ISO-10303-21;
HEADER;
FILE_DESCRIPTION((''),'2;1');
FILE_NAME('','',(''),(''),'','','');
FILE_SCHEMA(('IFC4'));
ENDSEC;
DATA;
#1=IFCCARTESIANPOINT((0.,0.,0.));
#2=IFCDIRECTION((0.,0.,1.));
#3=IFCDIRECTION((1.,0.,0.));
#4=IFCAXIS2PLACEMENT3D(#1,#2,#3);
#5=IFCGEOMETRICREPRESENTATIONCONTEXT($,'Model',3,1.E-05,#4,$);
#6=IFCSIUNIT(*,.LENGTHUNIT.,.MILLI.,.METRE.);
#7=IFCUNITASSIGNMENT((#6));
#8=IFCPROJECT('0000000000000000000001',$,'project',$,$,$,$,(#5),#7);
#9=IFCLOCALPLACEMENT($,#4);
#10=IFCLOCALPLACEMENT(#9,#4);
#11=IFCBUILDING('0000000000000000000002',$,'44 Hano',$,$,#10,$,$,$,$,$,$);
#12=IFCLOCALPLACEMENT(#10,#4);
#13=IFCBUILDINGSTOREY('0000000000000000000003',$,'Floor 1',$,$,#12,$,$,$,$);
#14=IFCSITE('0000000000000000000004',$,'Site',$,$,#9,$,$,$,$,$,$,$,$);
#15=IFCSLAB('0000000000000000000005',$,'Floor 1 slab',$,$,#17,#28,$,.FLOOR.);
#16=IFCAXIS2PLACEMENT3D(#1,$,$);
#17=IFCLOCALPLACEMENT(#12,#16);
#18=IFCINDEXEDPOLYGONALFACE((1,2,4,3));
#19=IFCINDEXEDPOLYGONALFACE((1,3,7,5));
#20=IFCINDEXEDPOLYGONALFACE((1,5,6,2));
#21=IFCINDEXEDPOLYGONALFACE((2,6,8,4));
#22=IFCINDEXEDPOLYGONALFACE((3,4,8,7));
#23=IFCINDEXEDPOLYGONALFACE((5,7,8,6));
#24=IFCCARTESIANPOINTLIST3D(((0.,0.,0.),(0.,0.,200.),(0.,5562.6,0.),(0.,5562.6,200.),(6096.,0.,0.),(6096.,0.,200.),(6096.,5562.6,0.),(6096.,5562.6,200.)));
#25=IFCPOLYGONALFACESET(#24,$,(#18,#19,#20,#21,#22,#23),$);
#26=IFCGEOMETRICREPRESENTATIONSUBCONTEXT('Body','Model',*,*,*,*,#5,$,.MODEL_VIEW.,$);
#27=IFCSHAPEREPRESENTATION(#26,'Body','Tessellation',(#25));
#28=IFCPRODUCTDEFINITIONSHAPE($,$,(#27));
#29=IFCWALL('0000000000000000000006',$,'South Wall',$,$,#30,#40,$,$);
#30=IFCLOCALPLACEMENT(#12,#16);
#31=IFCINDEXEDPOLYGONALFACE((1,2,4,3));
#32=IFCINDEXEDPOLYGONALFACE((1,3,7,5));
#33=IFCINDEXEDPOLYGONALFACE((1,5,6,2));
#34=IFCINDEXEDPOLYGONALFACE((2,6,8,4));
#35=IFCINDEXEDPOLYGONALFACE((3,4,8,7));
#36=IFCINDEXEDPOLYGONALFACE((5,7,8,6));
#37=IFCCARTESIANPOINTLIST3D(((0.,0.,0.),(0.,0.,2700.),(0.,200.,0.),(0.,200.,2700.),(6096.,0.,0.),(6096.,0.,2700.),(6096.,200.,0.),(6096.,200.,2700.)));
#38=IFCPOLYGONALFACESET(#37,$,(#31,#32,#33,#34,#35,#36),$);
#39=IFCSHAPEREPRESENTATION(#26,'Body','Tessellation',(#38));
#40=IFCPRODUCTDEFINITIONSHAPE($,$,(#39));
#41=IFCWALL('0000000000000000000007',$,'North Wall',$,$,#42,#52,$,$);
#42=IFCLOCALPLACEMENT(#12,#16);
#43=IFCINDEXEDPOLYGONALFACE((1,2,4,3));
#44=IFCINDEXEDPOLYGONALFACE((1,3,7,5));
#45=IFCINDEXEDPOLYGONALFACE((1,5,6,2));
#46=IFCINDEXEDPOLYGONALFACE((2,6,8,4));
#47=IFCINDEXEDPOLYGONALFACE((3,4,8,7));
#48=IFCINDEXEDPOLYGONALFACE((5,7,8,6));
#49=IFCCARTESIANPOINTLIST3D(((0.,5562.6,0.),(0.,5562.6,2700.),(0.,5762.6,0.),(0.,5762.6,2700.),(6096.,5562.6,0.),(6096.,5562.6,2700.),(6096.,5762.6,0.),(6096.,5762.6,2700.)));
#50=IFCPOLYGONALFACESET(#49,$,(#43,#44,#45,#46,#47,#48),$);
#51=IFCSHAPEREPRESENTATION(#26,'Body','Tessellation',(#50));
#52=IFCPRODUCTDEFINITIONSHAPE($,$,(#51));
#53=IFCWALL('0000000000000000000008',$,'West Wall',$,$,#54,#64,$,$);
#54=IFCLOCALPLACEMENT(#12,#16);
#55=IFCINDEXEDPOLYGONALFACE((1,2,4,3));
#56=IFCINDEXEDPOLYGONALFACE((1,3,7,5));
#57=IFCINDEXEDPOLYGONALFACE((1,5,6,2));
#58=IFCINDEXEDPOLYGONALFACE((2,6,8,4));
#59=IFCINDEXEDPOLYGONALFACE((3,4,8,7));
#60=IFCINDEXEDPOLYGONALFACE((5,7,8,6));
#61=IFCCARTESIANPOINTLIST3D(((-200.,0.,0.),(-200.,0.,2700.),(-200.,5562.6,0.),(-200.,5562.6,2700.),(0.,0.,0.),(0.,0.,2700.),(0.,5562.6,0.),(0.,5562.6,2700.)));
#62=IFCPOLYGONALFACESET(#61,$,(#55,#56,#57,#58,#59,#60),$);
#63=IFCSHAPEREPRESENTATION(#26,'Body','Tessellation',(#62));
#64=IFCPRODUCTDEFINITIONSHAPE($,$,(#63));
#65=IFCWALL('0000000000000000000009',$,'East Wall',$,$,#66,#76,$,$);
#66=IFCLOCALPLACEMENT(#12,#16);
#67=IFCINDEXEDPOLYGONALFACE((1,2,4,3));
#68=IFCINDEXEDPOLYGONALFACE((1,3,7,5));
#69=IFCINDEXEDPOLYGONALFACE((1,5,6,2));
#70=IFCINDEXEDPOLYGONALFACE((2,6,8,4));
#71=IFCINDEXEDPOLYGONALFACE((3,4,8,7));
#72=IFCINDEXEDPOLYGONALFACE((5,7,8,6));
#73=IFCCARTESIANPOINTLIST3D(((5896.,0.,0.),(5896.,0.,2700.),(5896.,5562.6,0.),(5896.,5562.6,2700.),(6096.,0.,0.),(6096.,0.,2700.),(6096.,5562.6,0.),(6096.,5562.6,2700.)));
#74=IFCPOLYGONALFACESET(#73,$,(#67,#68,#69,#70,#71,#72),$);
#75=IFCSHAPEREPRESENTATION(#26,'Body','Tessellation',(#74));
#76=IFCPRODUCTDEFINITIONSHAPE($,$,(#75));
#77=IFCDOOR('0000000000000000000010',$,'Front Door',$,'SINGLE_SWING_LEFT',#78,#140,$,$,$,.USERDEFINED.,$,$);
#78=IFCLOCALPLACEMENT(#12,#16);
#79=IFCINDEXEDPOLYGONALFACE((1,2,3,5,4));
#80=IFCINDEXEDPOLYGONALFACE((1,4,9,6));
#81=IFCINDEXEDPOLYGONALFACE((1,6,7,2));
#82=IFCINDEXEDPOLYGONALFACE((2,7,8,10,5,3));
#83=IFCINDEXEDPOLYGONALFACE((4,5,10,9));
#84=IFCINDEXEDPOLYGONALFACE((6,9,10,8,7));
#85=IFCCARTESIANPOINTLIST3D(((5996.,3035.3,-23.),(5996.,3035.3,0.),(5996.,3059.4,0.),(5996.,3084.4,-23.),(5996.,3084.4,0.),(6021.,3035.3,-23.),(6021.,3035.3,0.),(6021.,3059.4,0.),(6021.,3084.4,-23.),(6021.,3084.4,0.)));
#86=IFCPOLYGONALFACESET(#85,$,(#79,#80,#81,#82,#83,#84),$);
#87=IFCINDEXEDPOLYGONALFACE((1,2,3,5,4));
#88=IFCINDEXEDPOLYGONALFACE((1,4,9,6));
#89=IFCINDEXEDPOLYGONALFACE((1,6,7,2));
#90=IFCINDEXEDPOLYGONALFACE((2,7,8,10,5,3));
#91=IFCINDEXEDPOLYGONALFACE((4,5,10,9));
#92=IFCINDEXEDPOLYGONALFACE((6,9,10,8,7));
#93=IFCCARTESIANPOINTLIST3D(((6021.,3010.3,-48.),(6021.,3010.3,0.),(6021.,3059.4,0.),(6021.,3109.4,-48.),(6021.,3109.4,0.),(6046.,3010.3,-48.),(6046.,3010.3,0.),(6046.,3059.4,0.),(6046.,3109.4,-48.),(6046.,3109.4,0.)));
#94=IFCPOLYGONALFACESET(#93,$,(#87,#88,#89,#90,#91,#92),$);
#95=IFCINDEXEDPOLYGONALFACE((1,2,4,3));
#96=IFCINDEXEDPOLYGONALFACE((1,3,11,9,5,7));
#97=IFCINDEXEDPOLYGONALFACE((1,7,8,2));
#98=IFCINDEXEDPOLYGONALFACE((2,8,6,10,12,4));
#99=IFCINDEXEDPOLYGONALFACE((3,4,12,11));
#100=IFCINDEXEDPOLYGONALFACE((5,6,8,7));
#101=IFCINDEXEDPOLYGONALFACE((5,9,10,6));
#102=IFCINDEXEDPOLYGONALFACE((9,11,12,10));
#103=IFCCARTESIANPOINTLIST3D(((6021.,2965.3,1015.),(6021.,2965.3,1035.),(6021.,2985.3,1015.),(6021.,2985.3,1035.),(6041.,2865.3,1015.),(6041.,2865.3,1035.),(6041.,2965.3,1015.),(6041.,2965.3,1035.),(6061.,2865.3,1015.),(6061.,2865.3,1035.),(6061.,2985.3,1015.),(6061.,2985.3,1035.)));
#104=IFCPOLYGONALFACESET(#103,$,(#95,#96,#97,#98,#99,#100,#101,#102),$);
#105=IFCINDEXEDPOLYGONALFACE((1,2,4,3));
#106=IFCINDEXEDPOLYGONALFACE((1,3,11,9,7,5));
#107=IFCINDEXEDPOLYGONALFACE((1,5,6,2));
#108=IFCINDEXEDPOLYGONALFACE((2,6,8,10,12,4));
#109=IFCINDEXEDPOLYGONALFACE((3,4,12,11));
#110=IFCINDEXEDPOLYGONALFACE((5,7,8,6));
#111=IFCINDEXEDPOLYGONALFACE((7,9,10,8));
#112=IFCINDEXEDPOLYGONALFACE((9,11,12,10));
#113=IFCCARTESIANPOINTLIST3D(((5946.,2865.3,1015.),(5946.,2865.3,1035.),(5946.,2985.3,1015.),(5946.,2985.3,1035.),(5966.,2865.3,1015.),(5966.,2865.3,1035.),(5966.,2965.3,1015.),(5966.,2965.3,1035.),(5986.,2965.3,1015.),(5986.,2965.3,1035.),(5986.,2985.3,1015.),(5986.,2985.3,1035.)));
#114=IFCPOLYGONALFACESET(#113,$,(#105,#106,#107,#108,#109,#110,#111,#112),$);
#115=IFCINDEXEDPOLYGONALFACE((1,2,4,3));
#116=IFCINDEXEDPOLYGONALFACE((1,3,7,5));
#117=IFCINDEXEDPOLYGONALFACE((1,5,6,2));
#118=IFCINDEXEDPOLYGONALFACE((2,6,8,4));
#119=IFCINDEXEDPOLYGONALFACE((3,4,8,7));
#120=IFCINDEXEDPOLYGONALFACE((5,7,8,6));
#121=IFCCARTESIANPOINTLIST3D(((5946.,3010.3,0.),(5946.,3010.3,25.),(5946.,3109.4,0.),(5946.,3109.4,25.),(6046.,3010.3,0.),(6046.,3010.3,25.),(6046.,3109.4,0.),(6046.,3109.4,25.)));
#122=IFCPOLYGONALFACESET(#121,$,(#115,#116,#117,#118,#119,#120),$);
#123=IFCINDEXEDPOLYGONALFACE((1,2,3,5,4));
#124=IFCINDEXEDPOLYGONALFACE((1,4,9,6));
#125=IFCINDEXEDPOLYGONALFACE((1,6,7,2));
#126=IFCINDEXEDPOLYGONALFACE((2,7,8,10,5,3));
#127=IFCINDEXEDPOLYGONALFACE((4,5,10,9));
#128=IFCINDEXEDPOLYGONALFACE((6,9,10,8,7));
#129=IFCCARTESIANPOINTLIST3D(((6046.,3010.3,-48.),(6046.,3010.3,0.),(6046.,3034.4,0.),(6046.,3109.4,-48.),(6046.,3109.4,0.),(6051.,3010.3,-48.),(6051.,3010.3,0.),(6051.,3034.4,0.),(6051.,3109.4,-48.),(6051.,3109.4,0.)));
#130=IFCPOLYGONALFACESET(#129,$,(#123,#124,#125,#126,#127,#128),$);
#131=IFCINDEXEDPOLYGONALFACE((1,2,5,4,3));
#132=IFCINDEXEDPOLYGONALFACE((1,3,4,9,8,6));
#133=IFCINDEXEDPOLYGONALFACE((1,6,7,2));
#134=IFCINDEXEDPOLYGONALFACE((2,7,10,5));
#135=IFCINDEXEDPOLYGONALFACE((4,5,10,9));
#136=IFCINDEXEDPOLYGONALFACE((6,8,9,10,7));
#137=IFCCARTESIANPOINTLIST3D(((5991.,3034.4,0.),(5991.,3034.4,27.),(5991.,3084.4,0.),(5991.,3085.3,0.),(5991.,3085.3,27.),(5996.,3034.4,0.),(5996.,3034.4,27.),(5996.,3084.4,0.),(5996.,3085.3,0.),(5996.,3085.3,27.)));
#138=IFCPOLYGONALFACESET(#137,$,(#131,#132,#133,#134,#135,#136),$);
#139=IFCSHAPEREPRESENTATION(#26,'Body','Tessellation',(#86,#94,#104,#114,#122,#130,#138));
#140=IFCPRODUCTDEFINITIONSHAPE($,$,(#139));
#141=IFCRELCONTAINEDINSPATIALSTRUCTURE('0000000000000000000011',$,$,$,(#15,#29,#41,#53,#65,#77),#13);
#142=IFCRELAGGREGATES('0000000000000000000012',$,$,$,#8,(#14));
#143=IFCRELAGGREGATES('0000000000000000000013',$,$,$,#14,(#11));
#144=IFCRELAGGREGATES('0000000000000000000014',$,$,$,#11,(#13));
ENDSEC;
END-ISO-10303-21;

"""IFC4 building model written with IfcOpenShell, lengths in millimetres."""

from ifc_helpers import new_model, si_unit, frame, origin_with_axes, place, context, subcontext, project, spatial, line, indexed_curve, outline, extrude, element, save


model = new_model("IFC4")

# Units and contexts
model_context = context("Model", 3, precision=1e-05, world=origin_with_axes())
body_context = subcontext(model_context, "Body", "Model", "MODEL_VIEW")
ifc_project = project(units=[si_unit("LENGTHUNIT", "METRE", prefix="MILLI")], contexts=[model_context])

# Site, building, storey
site_placement = place(None, origin_with_axes())
site = spatial("IfcSite", under=ifc_project, at=site_placement, Name="Site")
building_placement = place(site_placement, origin_with_axes())
building = spatial("IfcBuilding", under=site, at=building_placement, Name="44 Hano")
storey_placement = place(building_placement, origin_with_axes())
storey = spatial("IfcBuildingStorey", under=building, at=storey_placement, Name="Floor 1")

# Slab
slab_placement = place(storey_placement, origin_with_axes())
element("IfcSlab", 1, at=slab_placement, inside=storey, Name="Floor 1 slab", PredefinedType="FLOOR", context=body_context, shape_type="SweptSolid", body=[
    extrude(outline(indexed_curve([(0.0, 0.0), (6096.0, 0.0), (6096.0, 5562.6), (0.0, 5562.6), (0.0, 0.0)])), None, (0.0, 0.0, 1.0), 200.0),
])

# Walls
for number, where, z_axis, x_axis, name in (
    (2, (0.0, 0.0, 0.0), (0.0, 0.0, 1.0), (1.0, 0.0, 0.0), "South Wall"),
    (3, (0.0, 5562.6, 0.0), (0.0, 0.0, 1.0), (1.0, 0.0, 0.0), "North Wall"),
):
    element("IfcWall", number, at=place(storey_placement, frame(where, z_axis=z_axis, x_axis=x_axis)), inside=storey, Name=name, context=body_context, shape_type="SweptSolid", body=[
        extrude(outline(indexed_curve([(0.0, 0.0), (0.0, 200.0), (6096.0, 200.0), (6096.0, 0.0), (0.0, 0.0)], self_intersect=False)), origin_with_axes(), (0.0, 0.0, 1.0), 2700.0),
    ])
for number, where, z_axis, x_axis, name in (
    (4, (0.0, 0.0, 0.0), (0.0, 0.0, 1.0), (0.0, 1.0, 0.0), "West Wall"),
    (5, (6096.0, 0.0, 0.0), (0.0, 0.0, 1.0), (0.0, 1.0, 0.0), "East Wall"),
):
    element("IfcWall", number, at=place(storey_placement, frame(where, z_axis=z_axis, x_axis=x_axis)), inside=storey, Name=name, context=body_context, shape_type="SweptSolid", body=[
        extrude(outline(indexed_curve([(0.0, 0.0), (0.0, 200.0), (5562.6, 200.0), (5562.6, 0.0), (0.0, 0.0)], self_intersect=False)), origin_with_axes(), (0.0, 0.0, 1.0), 2700.0),
    ])

# Door
door_placement = place(storey_placement, frame((6046.0, 3059.4, 0.0), z_axis=(0.0, 0.0, 1.0), x_axis=(0.0, 1.0, 0.0)))
element("IfcDoor", 6, at=door_placement, inside=storey, Name="Front Door", ObjectType="SINGLE_SWING_LEFT", PredefinedType="USERDEFINED", context=body_context, shape_type="SweptSolid", body=[
    extrude(outline(indexed_curve([(0.0, 0.0), (0.0, 2.0), (0.9, 2.0), (0.9, 0.0), (-24.1, 0.0), (-24.1, -23.0), (25.0, -23.0), (25.0, 0.0)], segments=[line(1, 2, 3, 4, 5, 6, 7, 8, 1)])), frame((0.0, 25.0, 0.0), z_axis=(0.0, -1.0, 0.0), x_axis=(1.0, 0.0, 0.0)), (0.0, 0.0, -1.0), 25.0),
    extrude(outline(indexed_curve([(0.0, 0.0), (0.0, 2.0), (0.9, 2.0), (0.9, 0.0), (-49.1, 0.0), (-49.1, -48.0), (50.0, -48.0), (50.0, 0.0)], segments=[line(1, 2, 3, 4, 5, 6, 7, 8, 1)])), frame((0.0, 0.0, 0.0), z_axis=(0.0, -1.0, 0.0), x_axis=(1.0, 0.0, 0.0)), (0.0, 0.0, -1.0), 25.0),
    extrude(outline(indexed_curve([(0.0, 0.0), (-49.1, 0.0), (-49.1, 35.0), (0.0, 35.0)], segments=[line(1, 2, 3, 4, 1)])), frame((25.0, 25.0, 25.0), z_axis=(0.0, 0.0, 1.0), x_axis=(1.0, 0.0, 0.0)), (0.0, 0.0, 1.0), -48.0),
    extrude(outline(indexed_curve([(0.0, 0.0), (0.0, -40.0), (-120.0, -40.0), (-120.0, -20.0), (-20.0, -20.0), (-20.0, 0.0)], segments=[line(1, 2, 3, 4, 5, 6, 1)])), frame((-74.1, 25.0, 1015.0), z_axis=(0.0, 0.0, 1.0), x_axis=(1.0, 0.0, 0.0)), (0.0, 0.0, 1.0), 20.0),
    extrude(outline(indexed_curve([(0.0, 0.0), (0.0, 40.0), (-120.0, 40.0), (-120.0, 20.0), (-20.0, 20.0), (-20.0, 0.0)], segments=[line(1, 2, 3, 4, 5, 6, 1)])), frame((-74.1, 60.0, 1015.0), z_axis=(0.0, 0.0, 1.0), x_axis=(1.0, 0.0, 0.0)), (0.0, 0.0, 1.0), 20.0),
    extrude(outline(indexed_curve([(0.0, 0.0), (-99.1, 0.0), (-99.1, 100.0), (0.0, 100.0)], segments=[line(1, 2, 3, 4, 1)])), frame((50.0, 0.0, 0.0), z_axis=(0.0, 0.0, 1.0), x_axis=(1.0, 0.0, 0.0)), (0.0, 0.0, 1.0), 25.0),
    extrude(outline(indexed_curve([(0.0, 0.0), (0.0, 27.0), (50.9, 27.0), (50.9, 0.0), (-24.1, 0.0), (-24.1, -48.0), (75.0, -48.0), (75.0, 0.0)], segments=[line(1, 2, 3, 4, 5, 6, 7, 8, 1)])), frame((-25.0, -5.0, 0.0), z_axis=(0.0, -1.0, 0.0), x_axis=(1.0, 0.0, 0.0)), (0.0, 0.0, -1.0), 5.0),
    extrude(outline(indexed_curve([(0.0, 0.0), (0.0, 27.0), (50.9, 27.0), (50.9, 0.0), (0.9, 0.0), (0.9, -23.0), (50.0, -23.0), (50.0, 0.0)], segments=[line(1, 2, 3, 4, 5, 6, 7, 8, 1)])), frame((-25.0, 50.0, 0.0), z_axis=(0.0, -1.0, 0.0), x_axis=(1.0, 0.0, 0.0)), (0.0, 0.0, -1.0), 5.0),
])

save(model, "model.ifc")
